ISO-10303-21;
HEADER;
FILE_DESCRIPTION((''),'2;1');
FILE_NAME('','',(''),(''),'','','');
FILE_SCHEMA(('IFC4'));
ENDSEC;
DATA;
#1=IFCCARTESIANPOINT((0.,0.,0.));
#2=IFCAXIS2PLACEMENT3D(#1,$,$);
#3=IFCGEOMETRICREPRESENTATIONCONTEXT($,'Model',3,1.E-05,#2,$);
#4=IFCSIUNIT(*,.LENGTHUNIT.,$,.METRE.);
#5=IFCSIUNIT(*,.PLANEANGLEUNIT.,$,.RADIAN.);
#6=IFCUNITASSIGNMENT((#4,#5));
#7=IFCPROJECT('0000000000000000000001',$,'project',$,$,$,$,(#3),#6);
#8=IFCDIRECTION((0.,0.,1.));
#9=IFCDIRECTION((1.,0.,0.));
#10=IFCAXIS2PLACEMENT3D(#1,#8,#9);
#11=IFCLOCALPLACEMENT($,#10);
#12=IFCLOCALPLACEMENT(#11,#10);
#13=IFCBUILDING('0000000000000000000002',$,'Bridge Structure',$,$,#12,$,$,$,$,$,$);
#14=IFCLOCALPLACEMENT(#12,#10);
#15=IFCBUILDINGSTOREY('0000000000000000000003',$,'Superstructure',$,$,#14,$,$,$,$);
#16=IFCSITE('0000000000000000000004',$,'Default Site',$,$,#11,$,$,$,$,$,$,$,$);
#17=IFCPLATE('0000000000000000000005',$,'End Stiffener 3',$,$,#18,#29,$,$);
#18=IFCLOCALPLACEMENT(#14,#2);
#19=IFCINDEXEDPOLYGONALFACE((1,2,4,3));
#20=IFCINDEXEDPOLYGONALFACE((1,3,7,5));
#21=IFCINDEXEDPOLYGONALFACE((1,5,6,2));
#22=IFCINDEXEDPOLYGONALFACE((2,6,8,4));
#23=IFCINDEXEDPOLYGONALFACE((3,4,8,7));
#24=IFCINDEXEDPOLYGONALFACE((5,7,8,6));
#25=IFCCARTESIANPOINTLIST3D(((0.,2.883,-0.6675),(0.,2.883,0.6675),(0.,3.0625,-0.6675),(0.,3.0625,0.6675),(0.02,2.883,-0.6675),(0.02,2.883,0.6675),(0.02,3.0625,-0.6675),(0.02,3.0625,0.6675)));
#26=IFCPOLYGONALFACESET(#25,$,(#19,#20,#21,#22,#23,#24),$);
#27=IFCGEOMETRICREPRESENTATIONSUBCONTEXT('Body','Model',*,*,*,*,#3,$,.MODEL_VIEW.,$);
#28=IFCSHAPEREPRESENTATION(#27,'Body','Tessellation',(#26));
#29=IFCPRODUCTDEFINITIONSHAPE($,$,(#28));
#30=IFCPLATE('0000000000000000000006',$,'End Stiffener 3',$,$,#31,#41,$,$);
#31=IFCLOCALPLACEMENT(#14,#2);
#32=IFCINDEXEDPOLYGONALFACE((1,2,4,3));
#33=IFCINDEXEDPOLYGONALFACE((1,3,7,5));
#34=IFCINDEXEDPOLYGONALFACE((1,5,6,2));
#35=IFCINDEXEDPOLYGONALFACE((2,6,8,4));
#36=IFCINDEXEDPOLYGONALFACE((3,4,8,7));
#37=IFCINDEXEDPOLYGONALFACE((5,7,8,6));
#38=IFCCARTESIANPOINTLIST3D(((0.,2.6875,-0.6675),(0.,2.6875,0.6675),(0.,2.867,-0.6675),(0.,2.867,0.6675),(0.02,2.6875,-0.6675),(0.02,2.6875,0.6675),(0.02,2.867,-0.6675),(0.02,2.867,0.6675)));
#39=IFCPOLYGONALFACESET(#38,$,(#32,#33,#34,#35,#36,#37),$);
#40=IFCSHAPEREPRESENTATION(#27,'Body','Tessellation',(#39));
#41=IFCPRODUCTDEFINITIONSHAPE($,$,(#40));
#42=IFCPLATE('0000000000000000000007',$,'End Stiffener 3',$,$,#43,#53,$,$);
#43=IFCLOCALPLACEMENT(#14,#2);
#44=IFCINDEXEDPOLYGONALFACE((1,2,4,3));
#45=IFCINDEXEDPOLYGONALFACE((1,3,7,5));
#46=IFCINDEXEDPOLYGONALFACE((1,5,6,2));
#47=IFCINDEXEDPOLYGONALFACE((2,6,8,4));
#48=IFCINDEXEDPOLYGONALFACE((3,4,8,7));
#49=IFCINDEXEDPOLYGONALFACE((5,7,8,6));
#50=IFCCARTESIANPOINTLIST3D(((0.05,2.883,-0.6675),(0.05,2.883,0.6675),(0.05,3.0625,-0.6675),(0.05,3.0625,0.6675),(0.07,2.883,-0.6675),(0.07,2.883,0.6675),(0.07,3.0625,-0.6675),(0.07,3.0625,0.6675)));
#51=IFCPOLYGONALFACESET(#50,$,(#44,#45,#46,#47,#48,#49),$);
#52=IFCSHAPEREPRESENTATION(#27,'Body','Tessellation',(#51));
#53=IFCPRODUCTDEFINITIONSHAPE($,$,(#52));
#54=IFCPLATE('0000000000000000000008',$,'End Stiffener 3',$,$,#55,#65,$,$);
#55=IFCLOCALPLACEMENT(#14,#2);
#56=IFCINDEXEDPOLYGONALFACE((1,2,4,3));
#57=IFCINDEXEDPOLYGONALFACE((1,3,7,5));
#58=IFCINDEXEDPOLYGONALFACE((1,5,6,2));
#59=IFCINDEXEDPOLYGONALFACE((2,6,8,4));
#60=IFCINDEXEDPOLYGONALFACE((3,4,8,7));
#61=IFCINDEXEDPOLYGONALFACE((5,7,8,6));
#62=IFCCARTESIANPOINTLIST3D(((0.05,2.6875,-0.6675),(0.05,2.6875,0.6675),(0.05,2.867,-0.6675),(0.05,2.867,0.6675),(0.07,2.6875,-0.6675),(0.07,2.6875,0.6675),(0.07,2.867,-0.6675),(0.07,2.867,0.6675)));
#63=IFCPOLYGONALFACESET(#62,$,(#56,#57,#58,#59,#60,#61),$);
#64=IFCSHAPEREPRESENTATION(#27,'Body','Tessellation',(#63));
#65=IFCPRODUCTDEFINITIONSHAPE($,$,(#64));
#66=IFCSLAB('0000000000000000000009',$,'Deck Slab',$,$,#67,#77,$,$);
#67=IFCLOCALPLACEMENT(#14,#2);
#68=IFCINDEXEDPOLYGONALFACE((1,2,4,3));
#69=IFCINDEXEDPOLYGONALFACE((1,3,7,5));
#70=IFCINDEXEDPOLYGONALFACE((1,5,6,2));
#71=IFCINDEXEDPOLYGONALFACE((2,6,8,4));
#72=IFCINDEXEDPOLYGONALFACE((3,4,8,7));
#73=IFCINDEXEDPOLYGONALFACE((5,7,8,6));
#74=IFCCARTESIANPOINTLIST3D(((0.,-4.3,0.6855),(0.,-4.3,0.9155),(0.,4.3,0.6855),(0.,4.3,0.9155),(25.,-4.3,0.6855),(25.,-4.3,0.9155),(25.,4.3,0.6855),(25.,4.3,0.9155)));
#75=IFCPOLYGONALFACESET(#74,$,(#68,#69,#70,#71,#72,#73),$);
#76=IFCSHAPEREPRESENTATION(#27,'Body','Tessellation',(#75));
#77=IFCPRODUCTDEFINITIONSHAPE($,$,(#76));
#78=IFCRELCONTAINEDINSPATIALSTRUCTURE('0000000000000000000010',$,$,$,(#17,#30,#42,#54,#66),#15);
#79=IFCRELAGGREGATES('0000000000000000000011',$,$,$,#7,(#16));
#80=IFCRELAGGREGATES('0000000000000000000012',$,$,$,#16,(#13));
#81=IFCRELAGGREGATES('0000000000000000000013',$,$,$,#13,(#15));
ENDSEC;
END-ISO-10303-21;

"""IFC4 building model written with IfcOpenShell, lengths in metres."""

from ifc_helpers import new_model, si_unit, frame, origin, origin_with_axes, origin_2d_with_axis, place, context, subcontext, project, spatial, polyline, rectangle, outline, extrude, element, save


model = new_model("IFC4")

# Units and contexts
model_context = context("Model", 3, precision=1e-05, world=origin())
body_context = subcontext(model_context, "Body", "Model", "MODEL_VIEW")
ifc_project = project(units=[si_unit("LENGTHUNIT", "METRE"), si_unit("PLANEANGLEUNIT", "RADIAN")], contexts=[model_context])

# Site, building, storey
site_placement = place(None, origin_with_axes())
site = spatial("IfcSite", under=ifc_project, at=site_placement, Name="Default Site")
building_placement = place(site_placement, origin_with_axes())
building = spatial("IfcBuilding", under=site, at=building_placement, Name="Bridge Structure")
storey_placement = place(building_placement, origin_with_axes())
storey = spatial("IfcBuildingStorey", under=building, at=storey_placement, Name="Superstructure")

# Plates
for number, where, z_axis, x_axis, name in (
    (1, (0.01, 2.9728, -0.6675), (0.0, 0.0, 1.0), (1.0, 0.0, 0.0), "End Stiffener 3"),
    (2, (0.01, 2.7772, -0.6675), (0.0, 0.0, 1.0), (1.0, 0.0, 0.0), "End Stiffener 3"),
    (3, (0.06, 2.9728, -0.6675), (0.0, 0.0, 1.0), (1.0, 0.0, 0.0), "End Stiffener 3"),
    (4, (0.06, 2.7772, -0.6675), (0.0, 0.0, 1.0), (1.0, 0.0, 0.0), "End Stiffener 3"),
):
    element("IfcPlate", number, at=place(storey_placement, frame(where, z_axis=z_axis, x_axis=x_axis)), inside=storey, Name=name, context=body_context, shape_type="SweptSolid", body=[
        extrude(rectangle(XDim=0.02, YDim=0.1795, at=origin_2d_with_axis()), origin_with_axes(), (0.0, 0.0, 1.0), 1.335),
    ])

# Slab
slab_placement = place(storey_placement, frame((0.0, 0.0, 0.6855), z_axis=(0.0, 0.0, 1.0), x_axis=(1.0, 0.0, 0.0)))
element("IfcSlab", 5, at=slab_placement, inside=storey, Name="Deck Slab", context=body_context, shape_type="SweptSolid", body=[
    extrude(outline(polyline([(0.0, -4.3), (25.0, -4.3), (25.0, 4.3), (0.0, 4.3), (0.0, -4.3)])), origin_with_axes(), (0.0, 0.0, 1.0), 0.23),
])

save(model, "model.ifc")
